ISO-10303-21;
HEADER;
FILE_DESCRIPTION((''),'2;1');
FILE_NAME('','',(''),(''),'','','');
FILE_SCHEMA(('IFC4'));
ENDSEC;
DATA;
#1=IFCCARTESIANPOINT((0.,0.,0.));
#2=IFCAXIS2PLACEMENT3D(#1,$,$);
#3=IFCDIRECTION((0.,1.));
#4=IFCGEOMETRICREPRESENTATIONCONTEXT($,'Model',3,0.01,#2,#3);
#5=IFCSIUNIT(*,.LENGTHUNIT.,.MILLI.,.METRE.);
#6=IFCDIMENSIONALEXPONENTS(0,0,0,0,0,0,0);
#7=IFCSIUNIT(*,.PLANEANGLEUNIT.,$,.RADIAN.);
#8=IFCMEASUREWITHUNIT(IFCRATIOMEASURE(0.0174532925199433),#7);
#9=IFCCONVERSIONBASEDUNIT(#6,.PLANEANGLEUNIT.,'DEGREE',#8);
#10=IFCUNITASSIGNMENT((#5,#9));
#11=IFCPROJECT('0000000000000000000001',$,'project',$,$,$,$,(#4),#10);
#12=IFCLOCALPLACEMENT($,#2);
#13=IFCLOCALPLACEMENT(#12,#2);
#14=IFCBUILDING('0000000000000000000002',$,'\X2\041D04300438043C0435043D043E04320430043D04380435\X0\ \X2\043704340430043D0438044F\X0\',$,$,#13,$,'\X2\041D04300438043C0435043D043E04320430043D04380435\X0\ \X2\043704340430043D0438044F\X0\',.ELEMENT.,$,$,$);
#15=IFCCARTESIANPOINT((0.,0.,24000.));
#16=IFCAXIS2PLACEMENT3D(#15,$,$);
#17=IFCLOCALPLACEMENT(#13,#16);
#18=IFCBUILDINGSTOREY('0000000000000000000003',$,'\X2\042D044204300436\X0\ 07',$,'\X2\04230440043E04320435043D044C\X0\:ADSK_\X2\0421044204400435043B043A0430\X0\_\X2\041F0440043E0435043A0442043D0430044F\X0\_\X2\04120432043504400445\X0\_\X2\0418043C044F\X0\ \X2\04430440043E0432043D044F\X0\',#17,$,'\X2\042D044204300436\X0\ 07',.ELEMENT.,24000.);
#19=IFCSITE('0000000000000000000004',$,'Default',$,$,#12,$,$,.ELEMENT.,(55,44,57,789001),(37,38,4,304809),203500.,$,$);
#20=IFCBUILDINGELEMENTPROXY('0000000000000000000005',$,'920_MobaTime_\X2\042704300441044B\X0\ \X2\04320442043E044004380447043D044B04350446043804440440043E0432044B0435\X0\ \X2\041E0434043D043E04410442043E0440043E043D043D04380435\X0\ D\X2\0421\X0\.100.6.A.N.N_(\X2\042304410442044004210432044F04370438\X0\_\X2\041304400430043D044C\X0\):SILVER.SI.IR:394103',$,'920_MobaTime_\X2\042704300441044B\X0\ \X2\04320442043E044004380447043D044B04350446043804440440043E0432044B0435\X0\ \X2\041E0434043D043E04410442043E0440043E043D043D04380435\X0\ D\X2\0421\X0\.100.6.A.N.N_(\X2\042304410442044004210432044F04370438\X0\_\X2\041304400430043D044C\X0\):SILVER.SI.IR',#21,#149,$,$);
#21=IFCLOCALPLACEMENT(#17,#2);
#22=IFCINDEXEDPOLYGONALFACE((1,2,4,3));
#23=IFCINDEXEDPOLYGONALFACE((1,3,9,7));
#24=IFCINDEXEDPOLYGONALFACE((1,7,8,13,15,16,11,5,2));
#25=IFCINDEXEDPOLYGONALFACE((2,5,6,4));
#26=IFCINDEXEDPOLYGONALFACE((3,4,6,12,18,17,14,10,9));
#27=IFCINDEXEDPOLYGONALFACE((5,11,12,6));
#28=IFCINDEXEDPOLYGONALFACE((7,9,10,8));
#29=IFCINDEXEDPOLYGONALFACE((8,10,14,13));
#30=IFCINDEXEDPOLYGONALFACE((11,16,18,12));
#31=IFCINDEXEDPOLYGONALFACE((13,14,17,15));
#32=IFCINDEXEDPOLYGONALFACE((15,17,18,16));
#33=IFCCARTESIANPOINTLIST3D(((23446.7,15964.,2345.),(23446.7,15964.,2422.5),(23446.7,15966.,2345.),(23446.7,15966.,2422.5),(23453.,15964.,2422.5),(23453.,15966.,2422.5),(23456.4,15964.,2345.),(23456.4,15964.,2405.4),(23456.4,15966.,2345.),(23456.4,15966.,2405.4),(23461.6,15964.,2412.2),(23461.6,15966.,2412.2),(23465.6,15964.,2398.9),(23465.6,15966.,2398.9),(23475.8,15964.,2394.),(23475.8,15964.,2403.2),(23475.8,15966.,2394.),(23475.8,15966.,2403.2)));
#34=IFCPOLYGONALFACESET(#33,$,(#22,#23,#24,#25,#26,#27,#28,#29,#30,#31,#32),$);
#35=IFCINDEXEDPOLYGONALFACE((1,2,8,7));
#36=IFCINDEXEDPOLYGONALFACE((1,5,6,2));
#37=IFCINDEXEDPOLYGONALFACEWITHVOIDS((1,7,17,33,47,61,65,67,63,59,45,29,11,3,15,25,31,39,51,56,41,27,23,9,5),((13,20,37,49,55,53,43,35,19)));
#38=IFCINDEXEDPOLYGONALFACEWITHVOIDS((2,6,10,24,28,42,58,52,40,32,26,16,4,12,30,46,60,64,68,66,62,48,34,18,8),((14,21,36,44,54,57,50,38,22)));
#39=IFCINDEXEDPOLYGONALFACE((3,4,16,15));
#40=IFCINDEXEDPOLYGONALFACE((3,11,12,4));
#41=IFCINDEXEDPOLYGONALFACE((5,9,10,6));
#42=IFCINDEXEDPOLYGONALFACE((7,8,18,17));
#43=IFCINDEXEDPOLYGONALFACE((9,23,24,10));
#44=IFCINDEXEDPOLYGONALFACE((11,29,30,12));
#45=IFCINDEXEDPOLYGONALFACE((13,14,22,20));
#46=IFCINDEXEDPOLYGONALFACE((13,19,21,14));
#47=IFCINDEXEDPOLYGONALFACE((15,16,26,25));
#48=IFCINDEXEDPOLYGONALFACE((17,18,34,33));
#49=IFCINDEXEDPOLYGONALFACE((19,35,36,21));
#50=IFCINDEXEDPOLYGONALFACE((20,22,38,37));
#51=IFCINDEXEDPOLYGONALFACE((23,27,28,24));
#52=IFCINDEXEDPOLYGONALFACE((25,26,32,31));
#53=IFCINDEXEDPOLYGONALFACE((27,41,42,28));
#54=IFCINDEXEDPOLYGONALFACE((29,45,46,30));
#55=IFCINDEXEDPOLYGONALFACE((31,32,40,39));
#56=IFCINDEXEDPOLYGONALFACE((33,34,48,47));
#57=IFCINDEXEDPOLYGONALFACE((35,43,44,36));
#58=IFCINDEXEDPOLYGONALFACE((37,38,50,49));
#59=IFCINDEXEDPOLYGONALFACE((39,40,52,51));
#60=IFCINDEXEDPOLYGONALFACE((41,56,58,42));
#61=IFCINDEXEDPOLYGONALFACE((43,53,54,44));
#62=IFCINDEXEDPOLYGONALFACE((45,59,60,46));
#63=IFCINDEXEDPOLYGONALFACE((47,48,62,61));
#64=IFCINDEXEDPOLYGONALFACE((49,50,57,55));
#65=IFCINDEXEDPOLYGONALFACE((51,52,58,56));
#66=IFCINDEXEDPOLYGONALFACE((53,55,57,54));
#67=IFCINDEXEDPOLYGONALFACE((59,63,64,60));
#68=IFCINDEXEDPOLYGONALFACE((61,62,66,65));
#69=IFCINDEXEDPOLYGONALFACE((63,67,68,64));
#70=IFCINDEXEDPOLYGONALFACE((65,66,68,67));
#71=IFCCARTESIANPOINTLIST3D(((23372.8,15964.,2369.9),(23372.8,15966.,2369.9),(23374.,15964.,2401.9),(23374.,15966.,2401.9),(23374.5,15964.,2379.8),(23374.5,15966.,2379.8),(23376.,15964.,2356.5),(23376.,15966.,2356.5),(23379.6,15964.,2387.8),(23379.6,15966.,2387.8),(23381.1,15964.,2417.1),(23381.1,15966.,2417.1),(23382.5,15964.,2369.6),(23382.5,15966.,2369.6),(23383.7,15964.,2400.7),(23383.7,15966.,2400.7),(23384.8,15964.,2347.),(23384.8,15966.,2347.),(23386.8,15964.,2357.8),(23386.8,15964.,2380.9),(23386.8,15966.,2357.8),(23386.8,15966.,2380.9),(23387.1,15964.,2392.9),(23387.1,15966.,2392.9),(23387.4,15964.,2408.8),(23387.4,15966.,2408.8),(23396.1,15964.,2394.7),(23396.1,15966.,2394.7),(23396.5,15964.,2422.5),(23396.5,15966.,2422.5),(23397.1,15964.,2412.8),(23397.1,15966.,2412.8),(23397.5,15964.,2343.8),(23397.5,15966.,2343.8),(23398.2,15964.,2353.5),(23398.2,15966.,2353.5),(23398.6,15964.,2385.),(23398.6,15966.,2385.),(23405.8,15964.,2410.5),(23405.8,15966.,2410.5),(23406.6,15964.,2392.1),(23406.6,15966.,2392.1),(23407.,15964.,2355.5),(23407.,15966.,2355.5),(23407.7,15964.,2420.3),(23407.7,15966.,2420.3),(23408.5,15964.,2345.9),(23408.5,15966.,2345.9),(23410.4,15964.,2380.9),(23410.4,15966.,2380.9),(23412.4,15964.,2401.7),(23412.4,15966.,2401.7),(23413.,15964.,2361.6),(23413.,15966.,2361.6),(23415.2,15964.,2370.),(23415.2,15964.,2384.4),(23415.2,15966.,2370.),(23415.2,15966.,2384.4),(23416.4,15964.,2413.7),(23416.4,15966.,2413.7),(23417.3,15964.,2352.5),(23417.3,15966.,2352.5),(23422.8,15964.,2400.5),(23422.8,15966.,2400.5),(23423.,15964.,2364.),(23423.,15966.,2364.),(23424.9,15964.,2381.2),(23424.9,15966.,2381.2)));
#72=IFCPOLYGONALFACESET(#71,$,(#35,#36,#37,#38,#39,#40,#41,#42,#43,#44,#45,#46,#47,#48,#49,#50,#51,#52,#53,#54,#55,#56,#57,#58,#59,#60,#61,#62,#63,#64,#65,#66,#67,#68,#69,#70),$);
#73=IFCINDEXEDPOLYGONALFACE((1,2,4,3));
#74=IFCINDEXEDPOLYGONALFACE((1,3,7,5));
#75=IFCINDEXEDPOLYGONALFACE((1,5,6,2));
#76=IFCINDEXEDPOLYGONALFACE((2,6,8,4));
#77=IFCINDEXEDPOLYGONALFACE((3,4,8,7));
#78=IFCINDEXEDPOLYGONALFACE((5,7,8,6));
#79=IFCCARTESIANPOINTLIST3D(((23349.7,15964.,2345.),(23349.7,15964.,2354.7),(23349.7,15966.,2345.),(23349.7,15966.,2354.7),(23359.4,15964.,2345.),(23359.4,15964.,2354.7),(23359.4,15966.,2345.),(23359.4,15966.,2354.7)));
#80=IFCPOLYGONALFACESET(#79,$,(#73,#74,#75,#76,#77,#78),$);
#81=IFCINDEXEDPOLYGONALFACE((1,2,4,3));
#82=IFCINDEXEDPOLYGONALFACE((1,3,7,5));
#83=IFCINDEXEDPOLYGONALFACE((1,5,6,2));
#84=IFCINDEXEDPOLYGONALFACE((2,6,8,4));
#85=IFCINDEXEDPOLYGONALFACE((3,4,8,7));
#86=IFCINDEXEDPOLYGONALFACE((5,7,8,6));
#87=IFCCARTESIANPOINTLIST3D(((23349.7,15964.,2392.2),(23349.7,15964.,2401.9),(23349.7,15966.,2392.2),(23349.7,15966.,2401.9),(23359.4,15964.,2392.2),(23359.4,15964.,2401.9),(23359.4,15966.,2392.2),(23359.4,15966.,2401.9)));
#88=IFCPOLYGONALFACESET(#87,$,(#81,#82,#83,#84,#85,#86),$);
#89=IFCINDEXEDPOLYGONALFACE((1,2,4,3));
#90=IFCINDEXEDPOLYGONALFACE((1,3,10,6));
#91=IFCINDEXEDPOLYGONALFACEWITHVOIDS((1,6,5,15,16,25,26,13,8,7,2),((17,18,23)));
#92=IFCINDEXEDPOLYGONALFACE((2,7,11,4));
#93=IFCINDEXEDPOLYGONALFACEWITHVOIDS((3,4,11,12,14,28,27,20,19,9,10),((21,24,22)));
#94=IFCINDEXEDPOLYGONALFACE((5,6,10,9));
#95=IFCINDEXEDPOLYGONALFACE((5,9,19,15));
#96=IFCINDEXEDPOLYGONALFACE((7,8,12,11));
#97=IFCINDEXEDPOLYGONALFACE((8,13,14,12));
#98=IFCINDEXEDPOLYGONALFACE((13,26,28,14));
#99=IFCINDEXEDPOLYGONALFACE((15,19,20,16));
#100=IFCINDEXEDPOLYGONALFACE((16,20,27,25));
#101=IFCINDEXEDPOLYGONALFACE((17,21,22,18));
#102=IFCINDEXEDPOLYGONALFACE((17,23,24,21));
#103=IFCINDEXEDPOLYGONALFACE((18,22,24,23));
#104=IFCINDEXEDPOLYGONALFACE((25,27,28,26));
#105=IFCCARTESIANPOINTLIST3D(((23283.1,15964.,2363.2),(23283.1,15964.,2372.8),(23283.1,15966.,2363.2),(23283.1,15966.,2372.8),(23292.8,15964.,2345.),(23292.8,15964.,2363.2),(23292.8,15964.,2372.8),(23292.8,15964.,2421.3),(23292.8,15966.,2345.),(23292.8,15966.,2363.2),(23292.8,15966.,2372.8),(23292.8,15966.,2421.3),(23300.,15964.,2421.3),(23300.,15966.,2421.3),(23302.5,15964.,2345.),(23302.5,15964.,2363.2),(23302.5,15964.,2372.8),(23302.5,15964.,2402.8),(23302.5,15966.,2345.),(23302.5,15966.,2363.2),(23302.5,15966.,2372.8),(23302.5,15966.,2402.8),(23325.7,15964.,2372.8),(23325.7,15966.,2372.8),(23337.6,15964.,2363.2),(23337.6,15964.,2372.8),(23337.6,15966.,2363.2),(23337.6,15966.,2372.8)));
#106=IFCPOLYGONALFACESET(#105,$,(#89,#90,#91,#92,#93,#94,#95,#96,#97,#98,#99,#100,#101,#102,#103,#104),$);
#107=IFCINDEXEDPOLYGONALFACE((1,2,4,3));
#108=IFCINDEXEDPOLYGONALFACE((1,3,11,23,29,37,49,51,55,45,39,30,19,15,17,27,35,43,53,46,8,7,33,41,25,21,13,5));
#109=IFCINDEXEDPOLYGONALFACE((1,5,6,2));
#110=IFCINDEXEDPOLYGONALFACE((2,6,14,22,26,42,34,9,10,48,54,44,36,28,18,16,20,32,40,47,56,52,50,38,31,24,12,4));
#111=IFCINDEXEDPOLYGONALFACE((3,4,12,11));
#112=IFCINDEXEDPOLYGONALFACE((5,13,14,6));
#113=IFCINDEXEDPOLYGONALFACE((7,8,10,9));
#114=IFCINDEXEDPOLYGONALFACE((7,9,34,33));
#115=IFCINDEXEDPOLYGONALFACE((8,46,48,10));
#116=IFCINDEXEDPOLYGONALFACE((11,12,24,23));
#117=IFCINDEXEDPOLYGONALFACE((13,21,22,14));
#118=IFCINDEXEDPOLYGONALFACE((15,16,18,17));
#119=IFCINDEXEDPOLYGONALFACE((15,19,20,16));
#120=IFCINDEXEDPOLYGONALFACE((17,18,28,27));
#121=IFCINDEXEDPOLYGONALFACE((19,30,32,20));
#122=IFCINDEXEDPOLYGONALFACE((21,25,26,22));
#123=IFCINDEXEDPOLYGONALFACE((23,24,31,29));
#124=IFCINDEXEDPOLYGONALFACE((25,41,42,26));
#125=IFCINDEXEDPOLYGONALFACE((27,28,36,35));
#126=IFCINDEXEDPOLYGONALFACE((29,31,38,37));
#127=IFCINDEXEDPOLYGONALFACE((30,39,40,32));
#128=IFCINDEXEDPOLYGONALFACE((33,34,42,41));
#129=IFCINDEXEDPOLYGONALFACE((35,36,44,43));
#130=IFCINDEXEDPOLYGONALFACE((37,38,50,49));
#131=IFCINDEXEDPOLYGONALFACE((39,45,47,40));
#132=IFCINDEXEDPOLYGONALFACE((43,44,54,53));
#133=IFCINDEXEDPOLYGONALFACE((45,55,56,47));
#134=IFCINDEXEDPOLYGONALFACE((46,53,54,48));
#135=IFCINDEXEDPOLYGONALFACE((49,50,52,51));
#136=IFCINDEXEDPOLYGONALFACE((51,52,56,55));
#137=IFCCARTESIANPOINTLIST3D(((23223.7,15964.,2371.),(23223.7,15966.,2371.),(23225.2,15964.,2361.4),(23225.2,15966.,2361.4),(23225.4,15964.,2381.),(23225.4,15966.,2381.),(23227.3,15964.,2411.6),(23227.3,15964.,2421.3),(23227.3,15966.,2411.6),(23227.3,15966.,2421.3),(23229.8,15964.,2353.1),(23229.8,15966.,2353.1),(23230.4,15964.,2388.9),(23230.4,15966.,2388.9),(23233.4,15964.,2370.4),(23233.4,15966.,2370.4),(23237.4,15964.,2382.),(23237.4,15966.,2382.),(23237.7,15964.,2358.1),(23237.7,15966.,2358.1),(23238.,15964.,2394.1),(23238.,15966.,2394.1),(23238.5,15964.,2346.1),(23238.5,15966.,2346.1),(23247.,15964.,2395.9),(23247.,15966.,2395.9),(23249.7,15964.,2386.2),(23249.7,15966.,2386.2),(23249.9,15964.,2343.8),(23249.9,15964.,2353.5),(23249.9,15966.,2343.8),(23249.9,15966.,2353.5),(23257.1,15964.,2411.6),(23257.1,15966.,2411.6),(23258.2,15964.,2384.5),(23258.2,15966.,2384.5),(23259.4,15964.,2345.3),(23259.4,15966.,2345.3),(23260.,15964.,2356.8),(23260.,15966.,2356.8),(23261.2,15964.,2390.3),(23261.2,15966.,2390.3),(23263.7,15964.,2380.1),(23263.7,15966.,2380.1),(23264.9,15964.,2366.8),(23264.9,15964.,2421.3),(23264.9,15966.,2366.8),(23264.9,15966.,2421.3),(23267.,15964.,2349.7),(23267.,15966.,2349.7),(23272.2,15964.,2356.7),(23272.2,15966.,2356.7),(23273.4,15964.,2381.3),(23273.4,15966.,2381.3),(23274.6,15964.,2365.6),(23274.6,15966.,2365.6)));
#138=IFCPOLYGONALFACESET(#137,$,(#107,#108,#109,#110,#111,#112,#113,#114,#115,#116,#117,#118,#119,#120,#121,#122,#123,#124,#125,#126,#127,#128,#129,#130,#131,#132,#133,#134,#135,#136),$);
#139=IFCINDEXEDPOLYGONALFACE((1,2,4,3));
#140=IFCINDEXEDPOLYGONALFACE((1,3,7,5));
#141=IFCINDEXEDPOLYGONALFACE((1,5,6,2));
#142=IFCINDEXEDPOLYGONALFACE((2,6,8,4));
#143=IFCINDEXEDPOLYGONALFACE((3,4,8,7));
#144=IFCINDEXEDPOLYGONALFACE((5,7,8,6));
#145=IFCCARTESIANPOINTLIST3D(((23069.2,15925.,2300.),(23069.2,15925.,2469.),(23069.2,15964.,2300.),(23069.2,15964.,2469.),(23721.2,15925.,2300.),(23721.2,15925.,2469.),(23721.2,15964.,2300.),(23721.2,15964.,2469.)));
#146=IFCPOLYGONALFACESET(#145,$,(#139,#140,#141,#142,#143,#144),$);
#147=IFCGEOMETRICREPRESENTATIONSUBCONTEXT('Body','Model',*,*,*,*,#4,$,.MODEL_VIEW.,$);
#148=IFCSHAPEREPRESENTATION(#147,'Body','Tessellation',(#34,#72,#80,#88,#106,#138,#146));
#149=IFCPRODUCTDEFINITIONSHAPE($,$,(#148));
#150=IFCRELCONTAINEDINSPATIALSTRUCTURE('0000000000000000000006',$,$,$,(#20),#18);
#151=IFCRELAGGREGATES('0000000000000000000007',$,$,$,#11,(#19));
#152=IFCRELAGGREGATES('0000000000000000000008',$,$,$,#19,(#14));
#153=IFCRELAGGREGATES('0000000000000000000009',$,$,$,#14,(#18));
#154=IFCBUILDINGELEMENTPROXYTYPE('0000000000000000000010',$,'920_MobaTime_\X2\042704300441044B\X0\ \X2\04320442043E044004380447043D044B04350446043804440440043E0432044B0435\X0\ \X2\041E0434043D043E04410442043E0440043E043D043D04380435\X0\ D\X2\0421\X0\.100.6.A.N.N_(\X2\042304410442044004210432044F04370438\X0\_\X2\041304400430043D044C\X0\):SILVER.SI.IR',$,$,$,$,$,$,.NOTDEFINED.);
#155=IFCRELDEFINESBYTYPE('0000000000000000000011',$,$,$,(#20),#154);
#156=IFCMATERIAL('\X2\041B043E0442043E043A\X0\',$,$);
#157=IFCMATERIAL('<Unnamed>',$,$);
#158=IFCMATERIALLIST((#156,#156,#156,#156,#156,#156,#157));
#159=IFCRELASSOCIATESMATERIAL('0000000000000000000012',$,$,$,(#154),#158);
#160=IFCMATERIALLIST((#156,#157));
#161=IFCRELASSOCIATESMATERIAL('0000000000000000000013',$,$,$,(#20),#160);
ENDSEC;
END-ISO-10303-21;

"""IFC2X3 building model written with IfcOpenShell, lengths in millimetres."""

from ifc_helpers import new_model, entity, si_unit, converted_unit, direction, frame, origin, origin_2d_with_axis, place, context, subcontext, project, spatial, polyline, rectangle, outline, extrude, source, transform, mapped, material, material_list, type_object, type_shapes, element, save


model = new_model("IFC2X3")

# Units and contexts
model_context = context("Model", 3, precision=0.01, world=origin(), true_north=direction((0.0, 1.0)))
body_context = subcontext(model_context, "Body", "Model", "MODEL_VIEW")
ifc_project = project(units=[si_unit("LENGTHUNIT", "METRE", prefix="MILLI"), converted_unit("PLANEANGLEUNIT", "DEGREE", entity("IfcRatioMeasure", 0.0174532925199433), si_unit("PLANEANGLEUNIT", "RADIAN"), dimensions=[0, 0, 0, 0, 0, 0, 0])], contexts=[model_context])

# Site, building, storey
site_placement = place(None, frame((0.0, 0.0, 0.0)))
site = spatial("IfcSite", under=ifc_project, at=site_placement, Name="Default", CompositionType="ELEMENT", RefLatitude=(55, 44, 57, 789001), RefLongitude=(37, 38, 4, 304809), RefElevation=203500.0)
building_placement = place(site_placement, origin())
building = spatial("IfcBuilding", under=site, at=building_placement, Name="Наименование здания", LongName="Наименование здания", CompositionType="ELEMENT")
storey_placement = place(building_placement, frame((0.0, 0.0, 24000.0)))
storey = spatial("IfcBuildingStorey", under=building, at=storey_placement, Name="Этаж 07", ObjectType="Уровень:ADSK_Стрелка_Проектная_Вверх_Имя уровня", LongName="Этаж 07", CompositionType="ELEMENT", Elevation=24000.0)

# Building element proxy
ifc_material_1 = material(Name="Лоток")
ifc_material_2 = material(Name="<Unnamed>")
ifc_material_list_1 = material_list([ifc_material_1, ifc_material_1, ifc_material_1, ifc_material_1, ifc_material_1, ifc_material_1, ifc_material_2])
building_element_proxy_type = type_object("IfcBuildingElementProxyType", Name="920_MobaTime_Часы вторичныецифровые Односторонние DС.100.6.A.N.N_(УстрСвязи_Грань):SILVER.SI.IR", PredefinedType="NOTDEFINED", material=ifc_material_list_1)
shared_shape = source(origin(), body_context, "Body", "SweptSolid", [
    extrude(outline(polyline([(-49.3, -13.1), (28.2, -13.1), (28.2, -6.8), (17.9, 1.8), (8.9, 16.0), (-0.3, 16.0), (4.6, 5.8), (11.1, -3.4), (-49.3, -3.4), (-49.3, -13.1)])), frame((-64.6, 9.8, 39.0), z_axis=(0.0, 0.0, 1.0), x_axis=(0.0, 1.0, 0.0)), (0.0, 0.0, 1.0), 2.0),
    extrude(outline(polyline([(2.2, -27.6), (19.0, -27.6), (30.5, -16.1), (33.3, -4.9), (31.0, 5.8), (21.8, 17.2), (5.2, 27.3), (-11.1, 33.0), (-24.0, 32.7), (-33.6, 27.6), (-40.3, 18.6), (-42.8, 5.7), (-38.0, -6.3), (-27.2, -15.0), (-17.5, -17.7), (-8.2, -16.4), (-0.3, -11.9), (5.1, -4.5), (7.3, 6.2), (4.0, 17.2), (18.5, 7.3), (23.6, -2.4), (22.0, -11.4), (14.2, -18.4), (5.3, -18.3), (2.2, -27.6)]), holes=[polyline([(-9.0, 23.3), (-1.3, 14.4), (-2.6, 2.0), (-11.4, -7.0), (-23.4, -6.1), (-32.2, 2.9), (-31.2, 15.1), (-25.6, 22.1), (-17.5, 24.9), (-9.0, 23.3)])]), frame((-2.7, 3.6, 39.0), z_axis=(0.0, 0.0, 1.0), x_axis=(-0.427649, 0.903945, 0.0)), (0.0, 0.0, 1.0), 2.0),
    extrude(rectangle(XDim=9.7, YDim=9.7, at=origin_2d_with_axis()), frame((40.6, -34.7, 39.0)), (0.0, 0.0, 1.0), 2.0),
    extrude(rectangle(XDim=9.7, YDim=9.7, at=origin_2d_with_axis()), frame((40.6, 12.6, 39.0)), (0.0, 0.0, 1.0), 2.0),
    extrude(outline(polyline([(-0.9, -28.1), (8.8, -28.1), (8.8, -9.9), (18.5, -9.9), (18.5, -0.2), (8.8, -0.2), (8.8, 48.3), (1.5, 48.3), (-36.0, -0.2), (-36.0, -9.9), (-0.9, -9.9), (-0.9, -28.1)]), holes=[polyline([(-0.9, -0.2), (-24.1, -0.2), (-0.9, 29.7), (-0.9, -0.2)])]), frame((93.6, -11.4, 39.0)), (0.0, 0.0, 1.0), 2.0),
    extrude(outline(polyline([(3.3, -28.3), (12.5, -28.3), (20.5, -25.0), (26.8, -18.8), (30.7, -10.0), (31.4, 1.6), (26.9, 11.8), (20.1, 18.4), (11.1, 22.3), (1.0, 23.3), (-7.9, 20.4), (-14.9, 14.5), (-18.9, 6.2), (-17.1, -9.0), (-36.7, 0.5), (-29.1, 29.3), (-38.5, 31.7), (-48.1, -4.6), (-11.6, -23.0), (-8.0, -14.0), (-10.8, -7.6), (-10.2, 1.1), (-3.0, 11.8), (9.2, 12.8), (20.0, 5.4), (21.3, -7.5), (15.5, -16.4), (4.6, -18.6), (3.3, -28.3)])), frame((147.1, -8.5, 39.0), z_axis=(0.0, 0.0, 1.0), x_axis=(0.256974, -0.966418, 0.0)), (0.0, 0.0, 1.0), 2.0),
    extrude(rectangle(XDim=652.0, YDim=169.0, at=origin_2d_with_axis()), frame((0.0, 0.0, 0.0), z_axis=(0.0, 0.0, 1.0), x_axis=(-1.0, 0.0, 0.0)), (0.0, 0.0, 1.0), 39.0),
])
type_shapes(building_element_proxy_type, [shared_shape])
ifc_material_list_2 = material_list([ifc_material_1, ifc_material_2])
proxy_1_placement = place(storey_placement, frame((23395.2, 15925.0, 2384.5), z_axis=(0.0, 1.0, 0.0), x_axis=(-1.0, 0.0, 0.0)))
element("IfcBuildingElementProxy", 1, at=proxy_1_placement, inside=storey, type_object=building_element_proxy_type, material=ifc_material_list_2, Name="920_MobaTime_Часы вторичныецифровые Односторонние DС.100.6.A.N.N_(УстрСвязи_Грань):SILVER.SI.IR:394103", ObjectType="920_MobaTime_Часы вторичныецифровые Односторонние DС.100.6.A.N.N_(УстрСвязи_Грань):SILVER.SI.IR", context=body_context, shape_type="MappedRepresentation", body=[
    mapped(shared_shape, transform((0.0, 0.0, 0.0), scale=1.0)),
])

save(model, "model.ifc")
